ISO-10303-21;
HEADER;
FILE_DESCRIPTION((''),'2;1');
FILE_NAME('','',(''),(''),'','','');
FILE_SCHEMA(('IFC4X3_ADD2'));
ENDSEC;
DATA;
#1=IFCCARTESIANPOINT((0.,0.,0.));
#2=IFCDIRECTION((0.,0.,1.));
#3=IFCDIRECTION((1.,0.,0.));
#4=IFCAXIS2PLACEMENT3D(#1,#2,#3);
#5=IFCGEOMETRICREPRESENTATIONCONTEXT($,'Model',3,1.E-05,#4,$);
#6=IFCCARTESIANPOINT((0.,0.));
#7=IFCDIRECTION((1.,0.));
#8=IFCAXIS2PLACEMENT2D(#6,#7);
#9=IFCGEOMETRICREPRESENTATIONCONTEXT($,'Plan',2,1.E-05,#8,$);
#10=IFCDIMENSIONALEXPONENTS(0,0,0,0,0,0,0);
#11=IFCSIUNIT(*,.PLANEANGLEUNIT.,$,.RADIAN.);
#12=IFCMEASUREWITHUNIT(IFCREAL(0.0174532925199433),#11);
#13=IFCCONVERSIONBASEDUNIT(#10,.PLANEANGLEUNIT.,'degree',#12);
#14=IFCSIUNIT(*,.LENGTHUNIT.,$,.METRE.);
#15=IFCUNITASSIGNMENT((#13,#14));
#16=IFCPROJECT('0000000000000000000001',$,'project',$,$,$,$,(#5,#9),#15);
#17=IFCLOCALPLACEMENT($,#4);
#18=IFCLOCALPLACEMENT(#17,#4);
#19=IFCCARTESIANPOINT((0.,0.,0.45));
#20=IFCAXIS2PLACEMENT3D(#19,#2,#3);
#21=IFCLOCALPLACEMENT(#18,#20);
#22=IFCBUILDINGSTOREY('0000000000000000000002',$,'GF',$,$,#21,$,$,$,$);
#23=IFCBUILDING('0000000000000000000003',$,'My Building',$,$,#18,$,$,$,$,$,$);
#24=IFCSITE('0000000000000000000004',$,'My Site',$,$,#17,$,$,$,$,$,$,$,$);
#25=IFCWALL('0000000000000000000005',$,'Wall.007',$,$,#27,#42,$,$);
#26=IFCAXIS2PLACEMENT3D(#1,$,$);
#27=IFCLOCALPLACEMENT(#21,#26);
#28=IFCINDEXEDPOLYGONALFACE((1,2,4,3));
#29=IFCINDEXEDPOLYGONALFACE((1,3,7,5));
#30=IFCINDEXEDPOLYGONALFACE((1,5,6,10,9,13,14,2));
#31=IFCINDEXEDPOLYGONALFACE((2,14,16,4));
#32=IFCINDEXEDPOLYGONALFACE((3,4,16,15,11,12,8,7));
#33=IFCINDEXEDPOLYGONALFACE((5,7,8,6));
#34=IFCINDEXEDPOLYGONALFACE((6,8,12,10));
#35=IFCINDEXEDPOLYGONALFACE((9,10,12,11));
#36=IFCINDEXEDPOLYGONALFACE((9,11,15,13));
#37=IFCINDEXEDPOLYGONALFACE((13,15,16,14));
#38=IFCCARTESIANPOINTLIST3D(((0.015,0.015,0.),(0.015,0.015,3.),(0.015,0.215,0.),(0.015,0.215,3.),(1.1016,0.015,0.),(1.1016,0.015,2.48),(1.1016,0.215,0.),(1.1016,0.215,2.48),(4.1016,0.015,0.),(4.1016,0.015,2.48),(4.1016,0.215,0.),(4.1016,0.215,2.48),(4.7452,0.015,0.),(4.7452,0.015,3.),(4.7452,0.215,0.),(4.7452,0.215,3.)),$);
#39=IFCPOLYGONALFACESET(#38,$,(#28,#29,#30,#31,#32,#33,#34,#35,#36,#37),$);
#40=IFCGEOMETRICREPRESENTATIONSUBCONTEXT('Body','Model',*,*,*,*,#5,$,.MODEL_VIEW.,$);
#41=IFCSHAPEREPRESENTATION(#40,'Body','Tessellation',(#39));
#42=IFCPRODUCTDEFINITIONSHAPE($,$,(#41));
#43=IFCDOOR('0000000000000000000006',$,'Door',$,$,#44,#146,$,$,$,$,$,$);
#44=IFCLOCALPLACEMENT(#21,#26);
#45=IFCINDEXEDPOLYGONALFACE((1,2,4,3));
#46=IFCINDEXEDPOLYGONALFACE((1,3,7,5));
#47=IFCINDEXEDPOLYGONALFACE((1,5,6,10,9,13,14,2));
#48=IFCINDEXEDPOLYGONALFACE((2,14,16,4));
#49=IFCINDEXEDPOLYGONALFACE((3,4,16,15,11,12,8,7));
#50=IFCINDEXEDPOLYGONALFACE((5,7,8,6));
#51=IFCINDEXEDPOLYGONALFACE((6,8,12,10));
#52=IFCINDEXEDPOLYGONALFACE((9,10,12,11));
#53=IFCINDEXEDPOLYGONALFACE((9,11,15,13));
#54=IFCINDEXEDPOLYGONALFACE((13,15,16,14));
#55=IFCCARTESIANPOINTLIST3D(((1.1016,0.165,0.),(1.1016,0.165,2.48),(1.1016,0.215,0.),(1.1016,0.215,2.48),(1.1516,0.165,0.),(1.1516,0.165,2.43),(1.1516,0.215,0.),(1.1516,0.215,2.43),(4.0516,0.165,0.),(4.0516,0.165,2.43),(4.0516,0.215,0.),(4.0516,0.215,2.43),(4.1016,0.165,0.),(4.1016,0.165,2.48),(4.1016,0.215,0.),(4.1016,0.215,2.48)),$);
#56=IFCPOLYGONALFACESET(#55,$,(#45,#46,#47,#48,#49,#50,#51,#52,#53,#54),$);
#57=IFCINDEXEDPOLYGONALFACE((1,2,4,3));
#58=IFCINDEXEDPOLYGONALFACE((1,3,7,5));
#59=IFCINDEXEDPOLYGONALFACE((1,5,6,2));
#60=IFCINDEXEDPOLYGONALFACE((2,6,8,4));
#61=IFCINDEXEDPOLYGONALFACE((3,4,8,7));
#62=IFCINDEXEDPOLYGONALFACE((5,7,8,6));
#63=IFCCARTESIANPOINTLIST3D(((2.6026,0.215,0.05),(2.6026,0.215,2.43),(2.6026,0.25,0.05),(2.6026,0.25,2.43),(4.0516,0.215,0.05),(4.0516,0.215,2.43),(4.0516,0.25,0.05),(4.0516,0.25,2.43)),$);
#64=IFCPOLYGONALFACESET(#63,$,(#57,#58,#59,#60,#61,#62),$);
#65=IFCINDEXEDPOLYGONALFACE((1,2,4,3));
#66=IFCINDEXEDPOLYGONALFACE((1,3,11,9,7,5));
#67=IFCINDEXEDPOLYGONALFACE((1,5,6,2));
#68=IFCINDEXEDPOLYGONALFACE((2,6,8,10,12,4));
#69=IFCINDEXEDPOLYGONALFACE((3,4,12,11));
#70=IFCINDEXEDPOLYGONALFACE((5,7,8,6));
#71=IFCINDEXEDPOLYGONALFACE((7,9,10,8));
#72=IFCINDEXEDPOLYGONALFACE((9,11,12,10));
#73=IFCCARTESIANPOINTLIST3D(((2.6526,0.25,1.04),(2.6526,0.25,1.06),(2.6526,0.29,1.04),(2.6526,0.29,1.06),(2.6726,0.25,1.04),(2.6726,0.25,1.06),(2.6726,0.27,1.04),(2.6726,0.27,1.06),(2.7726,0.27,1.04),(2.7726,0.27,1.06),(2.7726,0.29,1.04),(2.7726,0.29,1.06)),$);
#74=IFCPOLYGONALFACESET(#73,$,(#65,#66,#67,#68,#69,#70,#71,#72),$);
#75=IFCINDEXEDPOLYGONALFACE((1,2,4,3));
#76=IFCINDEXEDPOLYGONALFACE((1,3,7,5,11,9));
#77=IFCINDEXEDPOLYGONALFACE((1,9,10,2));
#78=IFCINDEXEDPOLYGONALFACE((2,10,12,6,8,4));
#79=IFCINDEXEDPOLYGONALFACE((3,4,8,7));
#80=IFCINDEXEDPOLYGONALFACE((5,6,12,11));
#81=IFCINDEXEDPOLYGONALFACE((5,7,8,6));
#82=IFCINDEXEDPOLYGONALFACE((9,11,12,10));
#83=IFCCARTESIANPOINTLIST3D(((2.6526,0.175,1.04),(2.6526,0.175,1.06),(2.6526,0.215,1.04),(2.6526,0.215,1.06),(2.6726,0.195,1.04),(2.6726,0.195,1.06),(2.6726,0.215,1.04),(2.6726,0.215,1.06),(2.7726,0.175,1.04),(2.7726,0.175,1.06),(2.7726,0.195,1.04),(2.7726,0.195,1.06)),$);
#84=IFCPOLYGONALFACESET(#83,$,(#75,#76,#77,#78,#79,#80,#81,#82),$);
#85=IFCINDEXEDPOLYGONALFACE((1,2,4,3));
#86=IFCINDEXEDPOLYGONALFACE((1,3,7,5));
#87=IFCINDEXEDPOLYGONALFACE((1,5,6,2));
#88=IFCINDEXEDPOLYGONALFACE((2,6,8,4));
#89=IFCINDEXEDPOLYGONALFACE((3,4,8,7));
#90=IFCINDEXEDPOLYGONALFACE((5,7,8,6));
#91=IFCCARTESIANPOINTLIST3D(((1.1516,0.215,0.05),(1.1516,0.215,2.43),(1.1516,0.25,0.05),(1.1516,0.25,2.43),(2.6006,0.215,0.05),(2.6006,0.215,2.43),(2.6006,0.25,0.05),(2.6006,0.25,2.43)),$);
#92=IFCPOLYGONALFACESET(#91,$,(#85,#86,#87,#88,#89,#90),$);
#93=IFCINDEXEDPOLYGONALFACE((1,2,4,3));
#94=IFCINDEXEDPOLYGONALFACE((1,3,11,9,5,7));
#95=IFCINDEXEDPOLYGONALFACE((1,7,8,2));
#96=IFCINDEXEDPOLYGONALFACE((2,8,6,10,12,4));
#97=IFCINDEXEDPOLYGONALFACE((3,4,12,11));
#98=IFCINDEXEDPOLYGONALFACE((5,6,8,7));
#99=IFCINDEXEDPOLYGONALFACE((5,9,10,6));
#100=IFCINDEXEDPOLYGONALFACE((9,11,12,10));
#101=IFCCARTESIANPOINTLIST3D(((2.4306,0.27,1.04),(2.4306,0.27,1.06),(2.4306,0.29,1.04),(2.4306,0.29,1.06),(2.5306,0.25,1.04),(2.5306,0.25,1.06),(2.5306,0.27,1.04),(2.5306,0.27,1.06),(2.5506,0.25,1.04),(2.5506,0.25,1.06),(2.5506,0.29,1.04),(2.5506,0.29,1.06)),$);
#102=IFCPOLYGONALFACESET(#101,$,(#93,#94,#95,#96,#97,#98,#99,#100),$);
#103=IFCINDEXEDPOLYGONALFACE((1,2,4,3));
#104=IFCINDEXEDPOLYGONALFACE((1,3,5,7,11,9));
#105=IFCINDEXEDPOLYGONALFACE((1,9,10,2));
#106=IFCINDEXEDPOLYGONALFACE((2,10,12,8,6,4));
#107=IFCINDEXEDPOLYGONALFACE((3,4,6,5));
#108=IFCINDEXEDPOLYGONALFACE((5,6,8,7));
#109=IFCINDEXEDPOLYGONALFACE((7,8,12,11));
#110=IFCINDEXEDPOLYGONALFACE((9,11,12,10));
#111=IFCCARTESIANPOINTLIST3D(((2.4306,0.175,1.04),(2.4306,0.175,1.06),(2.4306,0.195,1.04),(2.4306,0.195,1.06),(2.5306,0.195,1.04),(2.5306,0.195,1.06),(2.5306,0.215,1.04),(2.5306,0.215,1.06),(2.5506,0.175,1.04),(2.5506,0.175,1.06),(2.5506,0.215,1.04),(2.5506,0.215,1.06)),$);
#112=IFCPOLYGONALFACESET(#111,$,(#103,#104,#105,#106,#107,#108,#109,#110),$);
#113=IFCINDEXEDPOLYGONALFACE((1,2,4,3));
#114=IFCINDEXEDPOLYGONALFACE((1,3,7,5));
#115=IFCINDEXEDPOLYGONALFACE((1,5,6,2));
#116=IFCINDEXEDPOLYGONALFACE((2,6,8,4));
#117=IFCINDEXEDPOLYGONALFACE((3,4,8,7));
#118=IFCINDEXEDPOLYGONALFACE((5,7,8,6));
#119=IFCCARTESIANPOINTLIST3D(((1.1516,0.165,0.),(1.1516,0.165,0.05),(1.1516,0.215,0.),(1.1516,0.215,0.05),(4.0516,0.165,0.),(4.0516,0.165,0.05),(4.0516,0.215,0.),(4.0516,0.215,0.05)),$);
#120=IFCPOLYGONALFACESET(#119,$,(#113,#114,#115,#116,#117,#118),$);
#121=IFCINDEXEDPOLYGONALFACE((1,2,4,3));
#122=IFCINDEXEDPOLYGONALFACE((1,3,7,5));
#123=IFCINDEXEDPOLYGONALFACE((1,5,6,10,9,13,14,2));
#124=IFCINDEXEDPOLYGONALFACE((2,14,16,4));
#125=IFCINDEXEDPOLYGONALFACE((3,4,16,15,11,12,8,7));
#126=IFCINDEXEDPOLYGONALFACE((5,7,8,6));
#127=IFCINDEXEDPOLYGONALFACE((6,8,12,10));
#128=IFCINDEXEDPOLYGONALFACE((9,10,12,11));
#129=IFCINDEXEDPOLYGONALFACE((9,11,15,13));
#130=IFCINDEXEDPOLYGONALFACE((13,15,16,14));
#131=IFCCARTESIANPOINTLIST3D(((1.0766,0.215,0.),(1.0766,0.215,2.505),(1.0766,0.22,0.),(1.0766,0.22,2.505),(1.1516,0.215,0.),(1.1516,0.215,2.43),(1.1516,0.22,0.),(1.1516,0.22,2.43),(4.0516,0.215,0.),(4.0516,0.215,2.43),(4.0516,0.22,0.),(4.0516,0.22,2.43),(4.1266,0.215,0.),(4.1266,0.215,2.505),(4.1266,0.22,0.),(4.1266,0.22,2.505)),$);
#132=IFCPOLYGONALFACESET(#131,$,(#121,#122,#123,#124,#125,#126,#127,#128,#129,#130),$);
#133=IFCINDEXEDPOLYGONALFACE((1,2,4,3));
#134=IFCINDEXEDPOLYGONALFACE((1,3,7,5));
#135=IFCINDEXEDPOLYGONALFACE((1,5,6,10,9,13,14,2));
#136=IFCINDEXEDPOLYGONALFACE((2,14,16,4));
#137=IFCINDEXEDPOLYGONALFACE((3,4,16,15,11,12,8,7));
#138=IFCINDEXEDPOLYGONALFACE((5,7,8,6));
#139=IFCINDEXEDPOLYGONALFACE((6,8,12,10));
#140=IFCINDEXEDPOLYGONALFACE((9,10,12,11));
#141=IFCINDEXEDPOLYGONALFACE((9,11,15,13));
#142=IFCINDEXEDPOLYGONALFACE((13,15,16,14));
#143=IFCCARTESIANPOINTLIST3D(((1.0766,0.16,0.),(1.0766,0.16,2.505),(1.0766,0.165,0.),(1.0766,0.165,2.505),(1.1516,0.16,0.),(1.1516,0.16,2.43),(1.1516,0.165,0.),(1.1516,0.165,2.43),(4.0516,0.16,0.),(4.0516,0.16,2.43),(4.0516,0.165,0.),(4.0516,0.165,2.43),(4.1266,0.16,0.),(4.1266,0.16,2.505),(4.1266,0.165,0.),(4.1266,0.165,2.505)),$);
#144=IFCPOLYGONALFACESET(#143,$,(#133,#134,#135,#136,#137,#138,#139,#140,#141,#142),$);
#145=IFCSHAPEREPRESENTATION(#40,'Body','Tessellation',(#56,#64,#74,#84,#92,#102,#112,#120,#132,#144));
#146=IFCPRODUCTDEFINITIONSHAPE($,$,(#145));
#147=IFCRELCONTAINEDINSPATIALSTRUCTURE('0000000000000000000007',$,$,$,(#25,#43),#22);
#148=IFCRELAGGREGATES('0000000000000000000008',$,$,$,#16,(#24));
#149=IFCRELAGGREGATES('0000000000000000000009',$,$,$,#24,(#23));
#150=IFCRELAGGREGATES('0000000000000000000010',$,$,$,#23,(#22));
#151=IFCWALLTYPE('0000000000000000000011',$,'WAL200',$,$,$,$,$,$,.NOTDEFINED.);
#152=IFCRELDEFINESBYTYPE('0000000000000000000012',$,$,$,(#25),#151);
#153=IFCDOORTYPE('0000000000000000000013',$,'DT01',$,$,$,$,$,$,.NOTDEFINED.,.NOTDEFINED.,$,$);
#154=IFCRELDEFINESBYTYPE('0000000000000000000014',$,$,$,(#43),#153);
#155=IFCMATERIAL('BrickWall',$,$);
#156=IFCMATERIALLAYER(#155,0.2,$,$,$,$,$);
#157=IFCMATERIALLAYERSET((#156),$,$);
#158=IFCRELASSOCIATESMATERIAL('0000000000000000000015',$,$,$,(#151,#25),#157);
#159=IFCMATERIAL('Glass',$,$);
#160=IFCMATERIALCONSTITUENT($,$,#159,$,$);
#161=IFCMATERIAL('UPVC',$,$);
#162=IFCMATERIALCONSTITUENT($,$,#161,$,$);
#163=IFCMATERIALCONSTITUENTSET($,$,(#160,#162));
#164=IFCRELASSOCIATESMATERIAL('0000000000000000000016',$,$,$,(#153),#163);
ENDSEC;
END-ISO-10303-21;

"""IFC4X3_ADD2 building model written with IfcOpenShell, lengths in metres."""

from ifc_helpers import new_model, entity, si_unit, converted_unit, frame, origin_with_axes, origin_2d_with_axis, place, context, subcontext, project, spatial, line, indexed_curve, outline, extrude, shape, source, transform, mapped, material, layer, layer_set, layer_usage, constituent, constituent_set, type_object, type_shapes, element, fill, save


model = new_model("IFC4X3_ADD2")

# Units and contexts
model_context = context("Model", 3, precision=1e-05, world=origin_with_axes())
plan_context = context("Plan", 2, precision=1e-05, world=origin_2d_with_axis())
body_context_1 = subcontext(model_context, "Body", "Model", "MODEL_VIEW")
body_context_2 = subcontext(plan_context, "Body", "Plan", "PLAN_VIEW")
ifc_project = project(units=[converted_unit("PLANEANGLEUNIT", "degree", entity("IfcReal", 0.0174532925199433), si_unit("PLANEANGLEUNIT", "RADIAN"), dimensions=[0, 0, 0, 0, 0, 0, 0]), si_unit("LENGTHUNIT", "METRE")], contexts=[model_context, plan_context])

# Site, building, storey
site_placement = place(None, origin_with_axes())
site = spatial("IfcSite", under=ifc_project, at=site_placement, Name="My Site")
building_placement = place(site_placement, origin_with_axes())
building = spatial("IfcBuilding", under=site, at=building_placement, Name="My Building")
storey_placement = place(building_placement, frame((0.0, 0.0, 0.45), z_axis=(0.0, 0.0, 1.0), x_axis=(1.0, 0.0, 0.0)))
storey = spatial("IfcBuildingStorey", under=building, at=storey_placement, Name="GF")

# Shared definitions
ifc_material_1 = material(Name="BrickWall")
ifc_layer_1 = layer(ifc_material_1, 0.2)
ifc_layer_set_1 = layer_set([ifc_layer_1])
wall_type_1 = type_object("IfcWallType", Name="WAL200", PredefinedType="NOTDEFINED", material=ifc_layer_set_1)
shared_shape_1 = source(origin_with_axes(), body_context_1, "Body", "SweptSolid", [
    extrude(outline(indexed_curve([(0.0, 0.0), (3.0, 0.0), (3.0, 2.48), (0.0, 2.48)], segments=[line(1, 2, 3, 4, 1)])), frame((0.0, -0.6, 0.0), z_axis=(0.0, -1.0, 0.0), x_axis=(1.0, 0.0, 0.0)), (0.0, 0.0, -1.0), 1.2),
])
ifc_material_2 = material(Name="Glass")
ifc_constituent_1 = constituent(ifc_material_2)
ifc_material_3 = material(Name="UPVC")
ifc_constituent_2 = constituent(ifc_material_3)
ifc_constituent_set = constituent_set(constituents=[ifc_constituent_1, ifc_constituent_2])
door_type_1 = type_object("IfcDoorType", Name="DT01", OperationType="NOTDEFINED", PredefinedType="NOTDEFINED", material=ifc_constituent_set)
shared_shape_2 = source(origin_with_axes(), body_context_1, "Body", "SweptSolid", [
    extrude(outline(indexed_curve([(3.0, 0.0), (3.0, 2.48), (0.0, 2.48), (0.0, 0.0), (0.05, 0.0), (0.05, 2.43), (2.95, 2.43), (2.95, 0.0)], segments=[line(5, 4), line(4, 3), line(3, 2), line(2, 1), line(1, 8), line(8, 7), line(7, 6), line(6, 5)], self_intersect=False)), frame((0.0, 0.0, 0.0), z_axis=(0.0, -1.0, 0.0), x_axis=(1.0, 0.0, 0.0)), (0.0, 0.0, -1.0), 0.05),
    extrude(outline(indexed_curve([(0.0, 0.0), (1.449, 0.0), (1.449, 0.035), (0.0, 0.035)], segments=[line(1, 2, 3, 4, 1)])), frame((0.05, -0.035, 0.05), z_axis=(0.0, 0.0, 1.0), x_axis=(1.0, 0.0, 0.0)), (0.0, 0.0, 1.0), 2.38),
    extrude(outline(indexed_curve([(0.0, 0.0), (0.0, -0.04), (-0.12, -0.04), (-0.12, -0.02), (-0.02, -0.02), (-0.02, 0.0)], segments=[line(1, 2, 3, 4, 5, 6, 1)])), frame((1.449, -0.035, 1.04), z_axis=(0.0, 0.0, 1.0), x_axis=(1.0, 0.0, 0.0)), (0.0, 0.0, 1.0), 0.02),
    extrude(outline(indexed_curve([(0.0, 0.0), (0.0, 0.04), (-0.12, 0.04), (-0.12, 0.02), (-0.02, 0.02), (-0.02, 0.0)], segments=[line(1, 2, 3, 4, 5, 6, 1)])), frame((1.449, 0.0, 1.04), z_axis=(0.0, 0.0, 1.0), x_axis=(1.0, 0.0, 0.0)), (0.0, 0.0, 1.0), 0.02),
    extrude(outline(indexed_curve([(0.0, 0.0), (-1.449, 0.0), (-1.449, 0.035), (0.0, 0.035)], segments=[line(1, 2, 3, 4, 1)])), frame((2.95, -0.035, 0.05), z_axis=(0.0, 0.0, 1.0), x_axis=(1.0, 0.0, 0.0)), (0.0, 0.0, 1.0), 2.38),
    extrude(outline(indexed_curve([(0.0, 0.0), (0.0, -0.04), (0.12, -0.04), (0.12, -0.02), (0.02, -0.02), (0.02, 0.0)], segments=[line(1, 2, 3, 4, 5, 6, 1)])), frame((1.551, -0.035, 1.04), z_axis=(0.0, 0.0, 1.0), x_axis=(1.0, 0.0, 0.0)), (0.0, 0.0, 1.0), 0.02),
    extrude(outline(indexed_curve([(0.0, 0.0), (0.0, 0.04), (0.12, 0.04), (0.12, 0.02), (0.02, 0.02), (0.02, 0.0)], segments=[line(1, 2, 3, 4, 5, 6, 1)])), frame((1.551, 0.0, 1.04), z_axis=(0.0, 0.0, 1.0), x_axis=(1.0, 0.0, 0.0)), (0.0, 0.0, 1.0), 0.02),
    extrude(outline(indexed_curve([(0.0, 0.0), (2.9, 0.0), (2.9, 0.05), (0.0, 0.05)], segments=[line(1, 2, 3, 4, 1)])), frame((0.05, 0.0, 0.0), z_axis=(0.0, 0.0, 1.0), x_axis=(1.0, 0.0, 0.0)), (0.0, 0.0, 1.0), 0.05),
    extrude(outline(indexed_curve([(0.0, 0.0), (0.0, 2.505), (3.05, 2.505), (3.05, 0.0), (2.975, 0.0), (2.975, 2.43), (0.075, 2.43), (0.075, 0.0)], segments=[line(1, 2, 3, 4, 5, 6, 7, 8, 1)])), frame((-0.025, -0.005, 0.0), z_axis=(0.0, -1.0, 0.0), x_axis=(1.0, 0.0, 0.0)), (0.0, 0.0, -1.0), 0.005),
    extrude(outline(indexed_curve([(0.0, 0.0), (0.0, 2.505), (3.05, 2.505), (3.05, 0.0), (2.975, 0.0), (2.975, 2.43), (0.075, 2.43), (0.075, 0.0)], segments=[line(1, 2, 3, 4, 5, 6, 7, 8, 1)])), frame((-0.025, 0.05, 0.0), z_axis=(0.0, -1.0, 0.0), x_axis=(1.0, 0.0, 0.0)), (0.0, 0.0, -1.0), 0.005),
])
shared_shape_3 = source(origin_with_axes(), body_context_2, "Body", "Curve2D", [
    entity("IfcIndexedPolyCurve", entity("IfcCartesianPointList2D", [[0.0, 0.0], [0.05, 0.0], [0.05, 0.05], [0.0, 0.05]]), [entity("IfcLineIndex", [1, 2, 3, 4, 1])]),
    entity("IfcIndexedPolyCurve", entity("IfcCartesianPointList2D", [[3.0, 0.0], [2.95, 0.0], [2.95, 0.05], [3.0, 0.05]]), [entity("IfcLineIndex", [1, 2, 3, 4, 1])]),
    entity("IfcIndexedPolyCurve", entity("IfcCartesianPointList2D", [[-0.675, -0.035], [0.775, -0.035], [0.775, 0.0], [-0.675, 0.0]]), [entity("IfcLineIndex", [1, 2, 3, 4, 1])]),
    entity("IfcIndexedPolyCurve", entity("IfcCartesianPointList2D", [[3.675, -0.035], [2.225, -0.035], [2.225, 0.0], [3.675, 0.0]]), [entity("IfcLineIndex", [1, 2, 3, 4, 1])]),
])
type_shapes(door_type_1, [shared_shape_2, shared_shape_3])

# Wall, opening, door
ifc_layer_usage_1 = layer_usage(ifc_layer_set_1, "AXIS2", "POSITIVE", 0.0)
wall_1_placement = place(storey_placement, frame((4.7452, 0.215, 0.0), z_axis=(0.0, 0.0, 1.0), x_axis=(-1.0, 0.0, 0.0)))
wall_1 = element("IfcWall", 1, at=wall_1_placement, inside=storey, type_object=wall_type_1, material=ifc_layer_usage_1, Name="Wall.007", context=body_context_1, shape_type="SweptSolid", body=[
    extrude(outline(indexed_curve([(0.0, 0.0), (0.0, 0.2), (4.7302, 0.2), (4.7302, 0.0), (0.0, 0.0)], self_intersect=False)), origin_with_axes(), (0.0, 0.0, 1.0), 3.0),
])
opening_1_placement = place(wall_1_placement, frame((0.6436, 0.0, 0.0), z_axis=(0.0, 0.0, 1.0), x_axis=(1.0, 0.0, 0.0)))
opening_1 = element("IfcOpeningElement", 2, at=opening_1_placement, cuts=wall_1, PredefinedType="OPENING", context=body_context_1, shape_type="MappedRepresentation", body=[
    mapped(shared_shape_1, transform((0.0, 0.0, 0.0), x_axis=(1.0, 0.0, 0.0), y_axis=(0.0, 1.0, 0.0), z_axis=(0.0, 0.0, 1.0), scale=1.0)),
])
door_1_placement = place(opening_1_placement, frame((0.0, 0.0, 0.0), z_axis=(0.0, 0.0, 1.0), x_axis=(1.0, 0.0, 0.0)))
door_1 = element("IfcDoor", 3, at=door_1_placement, inside=storey, type_object=door_type_1, Name="Door", shapes=[
    shape(body_context_1, "Body", "MappedRepresentation", [mapped(shared_shape_2, transform((0.0, 0.0, 0.0), x_axis=(1.0, 0.0, 0.0), y_axis=(0.0, 1.0, 0.0), z_axis=(0.0, 0.0, 1.0), scale=1.0))]),
    shape(body_context_2, "Body", "MappedRepresentation", [mapped(shared_shape_3, transform((0.0, 0.0, 0.0), x_axis=(1.0, 0.0, 0.0), y_axis=(0.0, 1.0, 0.0), z_axis=(0.0, 0.0, 1.0), scale=1.0))]),
])
fill(opening_1, door_1)

save(model, "model.ifc")
